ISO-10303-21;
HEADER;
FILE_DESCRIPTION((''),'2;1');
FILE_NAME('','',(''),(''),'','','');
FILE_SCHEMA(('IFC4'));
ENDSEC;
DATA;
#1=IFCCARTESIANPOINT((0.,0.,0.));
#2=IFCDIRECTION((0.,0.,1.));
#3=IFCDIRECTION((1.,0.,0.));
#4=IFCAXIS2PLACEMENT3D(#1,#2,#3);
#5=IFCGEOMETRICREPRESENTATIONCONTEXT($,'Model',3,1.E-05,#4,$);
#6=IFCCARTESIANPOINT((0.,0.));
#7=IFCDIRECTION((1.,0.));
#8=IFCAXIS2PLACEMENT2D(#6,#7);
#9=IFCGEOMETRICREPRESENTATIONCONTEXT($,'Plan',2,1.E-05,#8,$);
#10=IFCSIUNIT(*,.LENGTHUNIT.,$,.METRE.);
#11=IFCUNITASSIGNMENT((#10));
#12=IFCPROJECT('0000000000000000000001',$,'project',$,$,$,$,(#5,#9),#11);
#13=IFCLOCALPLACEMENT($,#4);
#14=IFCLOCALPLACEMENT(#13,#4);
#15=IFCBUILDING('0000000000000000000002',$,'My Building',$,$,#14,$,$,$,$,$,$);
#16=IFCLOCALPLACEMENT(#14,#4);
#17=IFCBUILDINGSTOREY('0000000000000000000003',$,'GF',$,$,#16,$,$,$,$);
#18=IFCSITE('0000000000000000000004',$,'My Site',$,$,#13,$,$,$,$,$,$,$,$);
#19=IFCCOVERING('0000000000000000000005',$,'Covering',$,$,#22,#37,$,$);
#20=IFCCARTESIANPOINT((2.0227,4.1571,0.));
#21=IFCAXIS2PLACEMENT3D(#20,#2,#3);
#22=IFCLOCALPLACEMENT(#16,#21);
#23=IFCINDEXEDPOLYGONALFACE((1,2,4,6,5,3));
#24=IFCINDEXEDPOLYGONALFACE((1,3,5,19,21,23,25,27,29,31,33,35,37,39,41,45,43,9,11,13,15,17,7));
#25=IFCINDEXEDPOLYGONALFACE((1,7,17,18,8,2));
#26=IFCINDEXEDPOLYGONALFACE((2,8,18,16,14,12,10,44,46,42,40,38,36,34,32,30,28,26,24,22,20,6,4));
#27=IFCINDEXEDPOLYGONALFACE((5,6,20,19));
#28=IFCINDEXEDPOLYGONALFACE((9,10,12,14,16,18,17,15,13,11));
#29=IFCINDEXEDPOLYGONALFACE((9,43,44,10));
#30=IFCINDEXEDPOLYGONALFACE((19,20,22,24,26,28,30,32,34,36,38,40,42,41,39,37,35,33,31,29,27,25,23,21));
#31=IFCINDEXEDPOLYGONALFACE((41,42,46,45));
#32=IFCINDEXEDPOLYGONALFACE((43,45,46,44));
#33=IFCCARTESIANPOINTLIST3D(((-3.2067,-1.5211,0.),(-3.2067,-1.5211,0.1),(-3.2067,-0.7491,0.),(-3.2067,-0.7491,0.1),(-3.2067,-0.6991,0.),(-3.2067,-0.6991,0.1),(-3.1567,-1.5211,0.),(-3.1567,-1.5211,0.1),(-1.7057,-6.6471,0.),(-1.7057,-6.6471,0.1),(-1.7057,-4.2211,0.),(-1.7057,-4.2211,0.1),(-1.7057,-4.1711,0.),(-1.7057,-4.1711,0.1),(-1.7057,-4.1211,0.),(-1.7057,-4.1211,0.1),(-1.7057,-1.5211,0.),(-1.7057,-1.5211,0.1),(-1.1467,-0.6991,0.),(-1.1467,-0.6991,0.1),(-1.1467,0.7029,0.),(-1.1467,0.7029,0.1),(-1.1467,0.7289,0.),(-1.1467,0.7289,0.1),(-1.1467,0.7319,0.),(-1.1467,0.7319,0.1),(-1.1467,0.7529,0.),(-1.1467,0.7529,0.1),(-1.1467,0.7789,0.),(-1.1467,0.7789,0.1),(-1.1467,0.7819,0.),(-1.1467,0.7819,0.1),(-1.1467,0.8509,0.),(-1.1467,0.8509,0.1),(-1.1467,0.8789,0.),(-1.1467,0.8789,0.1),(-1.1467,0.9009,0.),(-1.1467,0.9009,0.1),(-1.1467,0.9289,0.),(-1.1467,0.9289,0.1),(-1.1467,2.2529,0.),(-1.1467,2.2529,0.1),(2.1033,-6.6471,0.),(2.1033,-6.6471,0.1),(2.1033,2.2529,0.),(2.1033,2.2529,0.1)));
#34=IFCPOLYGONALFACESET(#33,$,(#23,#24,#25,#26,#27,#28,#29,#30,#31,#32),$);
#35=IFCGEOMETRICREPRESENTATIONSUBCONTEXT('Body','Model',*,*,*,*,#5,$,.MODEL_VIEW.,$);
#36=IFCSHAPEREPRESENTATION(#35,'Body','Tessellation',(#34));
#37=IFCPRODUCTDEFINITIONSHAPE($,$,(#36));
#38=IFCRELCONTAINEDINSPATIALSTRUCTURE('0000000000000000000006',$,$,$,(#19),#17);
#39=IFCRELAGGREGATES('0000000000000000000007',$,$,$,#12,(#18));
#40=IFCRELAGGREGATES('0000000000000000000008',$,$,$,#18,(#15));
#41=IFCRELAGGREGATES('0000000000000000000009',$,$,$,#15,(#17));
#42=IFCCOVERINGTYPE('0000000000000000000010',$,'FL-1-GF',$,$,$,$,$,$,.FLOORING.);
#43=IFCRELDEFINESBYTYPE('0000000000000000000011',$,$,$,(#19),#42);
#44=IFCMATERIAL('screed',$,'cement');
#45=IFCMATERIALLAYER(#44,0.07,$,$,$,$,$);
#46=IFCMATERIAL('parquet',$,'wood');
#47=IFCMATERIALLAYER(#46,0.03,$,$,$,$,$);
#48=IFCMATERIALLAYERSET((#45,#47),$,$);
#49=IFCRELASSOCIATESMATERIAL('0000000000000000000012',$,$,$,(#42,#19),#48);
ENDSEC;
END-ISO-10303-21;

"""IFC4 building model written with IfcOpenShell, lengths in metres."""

from ifc_helpers import new_model, si_unit, frame, origin_with_axes, origin_2d_with_axis, place, context, subcontext, project, spatial, line, indexed_curve, outline, extrude, material, layer, layer_set, layer_usage, type_object, element, save


model = new_model("IFC4")

# Units and contexts
model_context = context("Model", 3, precision=1e-05, world=origin_with_axes())
plan_context = context("Plan", 2, precision=1e-05, world=origin_2d_with_axis())
body_context_1 = subcontext(model_context, "Body", "Model", "MODEL_VIEW")
ifc_project = project(units=[si_unit("LENGTHUNIT", "METRE")], contexts=[model_context, plan_context])

# Site, building, storey
site_placement = place(None, origin_with_axes())
site = spatial("IfcSite", under=ifc_project, at=site_placement, Name="My Site")
building_placement = place(site_placement, origin_with_axes())
building = spatial("IfcBuilding", under=site, at=building_placement, Name="My Building")
storey_placement = place(building_placement, origin_with_axes())
storey = spatial("IfcBuildingStorey", under=building, at=storey_placement, Name="GF")

# Covering
ifc_material_1 = material(Name="screed", Category="cement")
ifc_layer_1 = layer(ifc_material_1, 0.07)
ifc_material_2 = material(Name="parquet", Category="wood")
ifc_layer_2 = layer(ifc_material_2, 0.03)
ifc_layer_set_1 = layer_set([ifc_layer_1, ifc_layer_2])
ifc_layer_usage_1 = layer_usage(ifc_layer_set_1, "AXIS3", "POSITIVE", 0.0)
covering_type = type_object("IfcCoveringType", Name="FL-1-GF", PredefinedType="FLOORING", material=ifc_layer_set_1)
covering_placement = place(storey_placement, frame((2.0227, 4.1571, 0.0), z_axis=(0.0, 0.0, 1.0), x_axis=(1.0, 0.0, 0.0)))
element("IfcCovering", 1, at=covering_placement, inside=storey, type_object=covering_type, material=ifc_layer_usage_1, Name="Covering", context=body_context_1, shape_type="SweptSolid", body=[
    extrude(outline(indexed_curve([(-1.1467, 0.7029), (-1.1467, 0.7289), (-1.1467, 0.7319), (-1.1467, 0.7529), (-1.1467, 0.7789), (-1.1467, 0.7819), (-1.1467, 0.8509), (-1.1467, 0.8789), (-1.1467, 0.9009), (-1.1467, 0.9289), (-1.1467, 2.2529), (2.1033, 2.2529), (2.1033, -6.6471), (-1.7057, -6.6471), (-1.7057, -4.2211), (-1.7057, -4.1711), (-1.7057, -4.1711), (-1.7057, -4.1211), (-1.7057, -1.5211), (-3.1567, -1.5211), (-3.2067, -1.5211), (-3.2067, -0.7491), (-3.2067, -0.6991), (-1.1467, -0.6991)], segments=[line(1, 2, 3, 4, 5, 6, 7, 8, 9, 10, 11, 12, 13, 14, 15, 16, 17, 18, 19, 20, 21, 22, 23, 24, 1)])), origin_with_axes(), (0.0, 0.0, 1.0), 0.1),
])

save(model, "model.ifc")
